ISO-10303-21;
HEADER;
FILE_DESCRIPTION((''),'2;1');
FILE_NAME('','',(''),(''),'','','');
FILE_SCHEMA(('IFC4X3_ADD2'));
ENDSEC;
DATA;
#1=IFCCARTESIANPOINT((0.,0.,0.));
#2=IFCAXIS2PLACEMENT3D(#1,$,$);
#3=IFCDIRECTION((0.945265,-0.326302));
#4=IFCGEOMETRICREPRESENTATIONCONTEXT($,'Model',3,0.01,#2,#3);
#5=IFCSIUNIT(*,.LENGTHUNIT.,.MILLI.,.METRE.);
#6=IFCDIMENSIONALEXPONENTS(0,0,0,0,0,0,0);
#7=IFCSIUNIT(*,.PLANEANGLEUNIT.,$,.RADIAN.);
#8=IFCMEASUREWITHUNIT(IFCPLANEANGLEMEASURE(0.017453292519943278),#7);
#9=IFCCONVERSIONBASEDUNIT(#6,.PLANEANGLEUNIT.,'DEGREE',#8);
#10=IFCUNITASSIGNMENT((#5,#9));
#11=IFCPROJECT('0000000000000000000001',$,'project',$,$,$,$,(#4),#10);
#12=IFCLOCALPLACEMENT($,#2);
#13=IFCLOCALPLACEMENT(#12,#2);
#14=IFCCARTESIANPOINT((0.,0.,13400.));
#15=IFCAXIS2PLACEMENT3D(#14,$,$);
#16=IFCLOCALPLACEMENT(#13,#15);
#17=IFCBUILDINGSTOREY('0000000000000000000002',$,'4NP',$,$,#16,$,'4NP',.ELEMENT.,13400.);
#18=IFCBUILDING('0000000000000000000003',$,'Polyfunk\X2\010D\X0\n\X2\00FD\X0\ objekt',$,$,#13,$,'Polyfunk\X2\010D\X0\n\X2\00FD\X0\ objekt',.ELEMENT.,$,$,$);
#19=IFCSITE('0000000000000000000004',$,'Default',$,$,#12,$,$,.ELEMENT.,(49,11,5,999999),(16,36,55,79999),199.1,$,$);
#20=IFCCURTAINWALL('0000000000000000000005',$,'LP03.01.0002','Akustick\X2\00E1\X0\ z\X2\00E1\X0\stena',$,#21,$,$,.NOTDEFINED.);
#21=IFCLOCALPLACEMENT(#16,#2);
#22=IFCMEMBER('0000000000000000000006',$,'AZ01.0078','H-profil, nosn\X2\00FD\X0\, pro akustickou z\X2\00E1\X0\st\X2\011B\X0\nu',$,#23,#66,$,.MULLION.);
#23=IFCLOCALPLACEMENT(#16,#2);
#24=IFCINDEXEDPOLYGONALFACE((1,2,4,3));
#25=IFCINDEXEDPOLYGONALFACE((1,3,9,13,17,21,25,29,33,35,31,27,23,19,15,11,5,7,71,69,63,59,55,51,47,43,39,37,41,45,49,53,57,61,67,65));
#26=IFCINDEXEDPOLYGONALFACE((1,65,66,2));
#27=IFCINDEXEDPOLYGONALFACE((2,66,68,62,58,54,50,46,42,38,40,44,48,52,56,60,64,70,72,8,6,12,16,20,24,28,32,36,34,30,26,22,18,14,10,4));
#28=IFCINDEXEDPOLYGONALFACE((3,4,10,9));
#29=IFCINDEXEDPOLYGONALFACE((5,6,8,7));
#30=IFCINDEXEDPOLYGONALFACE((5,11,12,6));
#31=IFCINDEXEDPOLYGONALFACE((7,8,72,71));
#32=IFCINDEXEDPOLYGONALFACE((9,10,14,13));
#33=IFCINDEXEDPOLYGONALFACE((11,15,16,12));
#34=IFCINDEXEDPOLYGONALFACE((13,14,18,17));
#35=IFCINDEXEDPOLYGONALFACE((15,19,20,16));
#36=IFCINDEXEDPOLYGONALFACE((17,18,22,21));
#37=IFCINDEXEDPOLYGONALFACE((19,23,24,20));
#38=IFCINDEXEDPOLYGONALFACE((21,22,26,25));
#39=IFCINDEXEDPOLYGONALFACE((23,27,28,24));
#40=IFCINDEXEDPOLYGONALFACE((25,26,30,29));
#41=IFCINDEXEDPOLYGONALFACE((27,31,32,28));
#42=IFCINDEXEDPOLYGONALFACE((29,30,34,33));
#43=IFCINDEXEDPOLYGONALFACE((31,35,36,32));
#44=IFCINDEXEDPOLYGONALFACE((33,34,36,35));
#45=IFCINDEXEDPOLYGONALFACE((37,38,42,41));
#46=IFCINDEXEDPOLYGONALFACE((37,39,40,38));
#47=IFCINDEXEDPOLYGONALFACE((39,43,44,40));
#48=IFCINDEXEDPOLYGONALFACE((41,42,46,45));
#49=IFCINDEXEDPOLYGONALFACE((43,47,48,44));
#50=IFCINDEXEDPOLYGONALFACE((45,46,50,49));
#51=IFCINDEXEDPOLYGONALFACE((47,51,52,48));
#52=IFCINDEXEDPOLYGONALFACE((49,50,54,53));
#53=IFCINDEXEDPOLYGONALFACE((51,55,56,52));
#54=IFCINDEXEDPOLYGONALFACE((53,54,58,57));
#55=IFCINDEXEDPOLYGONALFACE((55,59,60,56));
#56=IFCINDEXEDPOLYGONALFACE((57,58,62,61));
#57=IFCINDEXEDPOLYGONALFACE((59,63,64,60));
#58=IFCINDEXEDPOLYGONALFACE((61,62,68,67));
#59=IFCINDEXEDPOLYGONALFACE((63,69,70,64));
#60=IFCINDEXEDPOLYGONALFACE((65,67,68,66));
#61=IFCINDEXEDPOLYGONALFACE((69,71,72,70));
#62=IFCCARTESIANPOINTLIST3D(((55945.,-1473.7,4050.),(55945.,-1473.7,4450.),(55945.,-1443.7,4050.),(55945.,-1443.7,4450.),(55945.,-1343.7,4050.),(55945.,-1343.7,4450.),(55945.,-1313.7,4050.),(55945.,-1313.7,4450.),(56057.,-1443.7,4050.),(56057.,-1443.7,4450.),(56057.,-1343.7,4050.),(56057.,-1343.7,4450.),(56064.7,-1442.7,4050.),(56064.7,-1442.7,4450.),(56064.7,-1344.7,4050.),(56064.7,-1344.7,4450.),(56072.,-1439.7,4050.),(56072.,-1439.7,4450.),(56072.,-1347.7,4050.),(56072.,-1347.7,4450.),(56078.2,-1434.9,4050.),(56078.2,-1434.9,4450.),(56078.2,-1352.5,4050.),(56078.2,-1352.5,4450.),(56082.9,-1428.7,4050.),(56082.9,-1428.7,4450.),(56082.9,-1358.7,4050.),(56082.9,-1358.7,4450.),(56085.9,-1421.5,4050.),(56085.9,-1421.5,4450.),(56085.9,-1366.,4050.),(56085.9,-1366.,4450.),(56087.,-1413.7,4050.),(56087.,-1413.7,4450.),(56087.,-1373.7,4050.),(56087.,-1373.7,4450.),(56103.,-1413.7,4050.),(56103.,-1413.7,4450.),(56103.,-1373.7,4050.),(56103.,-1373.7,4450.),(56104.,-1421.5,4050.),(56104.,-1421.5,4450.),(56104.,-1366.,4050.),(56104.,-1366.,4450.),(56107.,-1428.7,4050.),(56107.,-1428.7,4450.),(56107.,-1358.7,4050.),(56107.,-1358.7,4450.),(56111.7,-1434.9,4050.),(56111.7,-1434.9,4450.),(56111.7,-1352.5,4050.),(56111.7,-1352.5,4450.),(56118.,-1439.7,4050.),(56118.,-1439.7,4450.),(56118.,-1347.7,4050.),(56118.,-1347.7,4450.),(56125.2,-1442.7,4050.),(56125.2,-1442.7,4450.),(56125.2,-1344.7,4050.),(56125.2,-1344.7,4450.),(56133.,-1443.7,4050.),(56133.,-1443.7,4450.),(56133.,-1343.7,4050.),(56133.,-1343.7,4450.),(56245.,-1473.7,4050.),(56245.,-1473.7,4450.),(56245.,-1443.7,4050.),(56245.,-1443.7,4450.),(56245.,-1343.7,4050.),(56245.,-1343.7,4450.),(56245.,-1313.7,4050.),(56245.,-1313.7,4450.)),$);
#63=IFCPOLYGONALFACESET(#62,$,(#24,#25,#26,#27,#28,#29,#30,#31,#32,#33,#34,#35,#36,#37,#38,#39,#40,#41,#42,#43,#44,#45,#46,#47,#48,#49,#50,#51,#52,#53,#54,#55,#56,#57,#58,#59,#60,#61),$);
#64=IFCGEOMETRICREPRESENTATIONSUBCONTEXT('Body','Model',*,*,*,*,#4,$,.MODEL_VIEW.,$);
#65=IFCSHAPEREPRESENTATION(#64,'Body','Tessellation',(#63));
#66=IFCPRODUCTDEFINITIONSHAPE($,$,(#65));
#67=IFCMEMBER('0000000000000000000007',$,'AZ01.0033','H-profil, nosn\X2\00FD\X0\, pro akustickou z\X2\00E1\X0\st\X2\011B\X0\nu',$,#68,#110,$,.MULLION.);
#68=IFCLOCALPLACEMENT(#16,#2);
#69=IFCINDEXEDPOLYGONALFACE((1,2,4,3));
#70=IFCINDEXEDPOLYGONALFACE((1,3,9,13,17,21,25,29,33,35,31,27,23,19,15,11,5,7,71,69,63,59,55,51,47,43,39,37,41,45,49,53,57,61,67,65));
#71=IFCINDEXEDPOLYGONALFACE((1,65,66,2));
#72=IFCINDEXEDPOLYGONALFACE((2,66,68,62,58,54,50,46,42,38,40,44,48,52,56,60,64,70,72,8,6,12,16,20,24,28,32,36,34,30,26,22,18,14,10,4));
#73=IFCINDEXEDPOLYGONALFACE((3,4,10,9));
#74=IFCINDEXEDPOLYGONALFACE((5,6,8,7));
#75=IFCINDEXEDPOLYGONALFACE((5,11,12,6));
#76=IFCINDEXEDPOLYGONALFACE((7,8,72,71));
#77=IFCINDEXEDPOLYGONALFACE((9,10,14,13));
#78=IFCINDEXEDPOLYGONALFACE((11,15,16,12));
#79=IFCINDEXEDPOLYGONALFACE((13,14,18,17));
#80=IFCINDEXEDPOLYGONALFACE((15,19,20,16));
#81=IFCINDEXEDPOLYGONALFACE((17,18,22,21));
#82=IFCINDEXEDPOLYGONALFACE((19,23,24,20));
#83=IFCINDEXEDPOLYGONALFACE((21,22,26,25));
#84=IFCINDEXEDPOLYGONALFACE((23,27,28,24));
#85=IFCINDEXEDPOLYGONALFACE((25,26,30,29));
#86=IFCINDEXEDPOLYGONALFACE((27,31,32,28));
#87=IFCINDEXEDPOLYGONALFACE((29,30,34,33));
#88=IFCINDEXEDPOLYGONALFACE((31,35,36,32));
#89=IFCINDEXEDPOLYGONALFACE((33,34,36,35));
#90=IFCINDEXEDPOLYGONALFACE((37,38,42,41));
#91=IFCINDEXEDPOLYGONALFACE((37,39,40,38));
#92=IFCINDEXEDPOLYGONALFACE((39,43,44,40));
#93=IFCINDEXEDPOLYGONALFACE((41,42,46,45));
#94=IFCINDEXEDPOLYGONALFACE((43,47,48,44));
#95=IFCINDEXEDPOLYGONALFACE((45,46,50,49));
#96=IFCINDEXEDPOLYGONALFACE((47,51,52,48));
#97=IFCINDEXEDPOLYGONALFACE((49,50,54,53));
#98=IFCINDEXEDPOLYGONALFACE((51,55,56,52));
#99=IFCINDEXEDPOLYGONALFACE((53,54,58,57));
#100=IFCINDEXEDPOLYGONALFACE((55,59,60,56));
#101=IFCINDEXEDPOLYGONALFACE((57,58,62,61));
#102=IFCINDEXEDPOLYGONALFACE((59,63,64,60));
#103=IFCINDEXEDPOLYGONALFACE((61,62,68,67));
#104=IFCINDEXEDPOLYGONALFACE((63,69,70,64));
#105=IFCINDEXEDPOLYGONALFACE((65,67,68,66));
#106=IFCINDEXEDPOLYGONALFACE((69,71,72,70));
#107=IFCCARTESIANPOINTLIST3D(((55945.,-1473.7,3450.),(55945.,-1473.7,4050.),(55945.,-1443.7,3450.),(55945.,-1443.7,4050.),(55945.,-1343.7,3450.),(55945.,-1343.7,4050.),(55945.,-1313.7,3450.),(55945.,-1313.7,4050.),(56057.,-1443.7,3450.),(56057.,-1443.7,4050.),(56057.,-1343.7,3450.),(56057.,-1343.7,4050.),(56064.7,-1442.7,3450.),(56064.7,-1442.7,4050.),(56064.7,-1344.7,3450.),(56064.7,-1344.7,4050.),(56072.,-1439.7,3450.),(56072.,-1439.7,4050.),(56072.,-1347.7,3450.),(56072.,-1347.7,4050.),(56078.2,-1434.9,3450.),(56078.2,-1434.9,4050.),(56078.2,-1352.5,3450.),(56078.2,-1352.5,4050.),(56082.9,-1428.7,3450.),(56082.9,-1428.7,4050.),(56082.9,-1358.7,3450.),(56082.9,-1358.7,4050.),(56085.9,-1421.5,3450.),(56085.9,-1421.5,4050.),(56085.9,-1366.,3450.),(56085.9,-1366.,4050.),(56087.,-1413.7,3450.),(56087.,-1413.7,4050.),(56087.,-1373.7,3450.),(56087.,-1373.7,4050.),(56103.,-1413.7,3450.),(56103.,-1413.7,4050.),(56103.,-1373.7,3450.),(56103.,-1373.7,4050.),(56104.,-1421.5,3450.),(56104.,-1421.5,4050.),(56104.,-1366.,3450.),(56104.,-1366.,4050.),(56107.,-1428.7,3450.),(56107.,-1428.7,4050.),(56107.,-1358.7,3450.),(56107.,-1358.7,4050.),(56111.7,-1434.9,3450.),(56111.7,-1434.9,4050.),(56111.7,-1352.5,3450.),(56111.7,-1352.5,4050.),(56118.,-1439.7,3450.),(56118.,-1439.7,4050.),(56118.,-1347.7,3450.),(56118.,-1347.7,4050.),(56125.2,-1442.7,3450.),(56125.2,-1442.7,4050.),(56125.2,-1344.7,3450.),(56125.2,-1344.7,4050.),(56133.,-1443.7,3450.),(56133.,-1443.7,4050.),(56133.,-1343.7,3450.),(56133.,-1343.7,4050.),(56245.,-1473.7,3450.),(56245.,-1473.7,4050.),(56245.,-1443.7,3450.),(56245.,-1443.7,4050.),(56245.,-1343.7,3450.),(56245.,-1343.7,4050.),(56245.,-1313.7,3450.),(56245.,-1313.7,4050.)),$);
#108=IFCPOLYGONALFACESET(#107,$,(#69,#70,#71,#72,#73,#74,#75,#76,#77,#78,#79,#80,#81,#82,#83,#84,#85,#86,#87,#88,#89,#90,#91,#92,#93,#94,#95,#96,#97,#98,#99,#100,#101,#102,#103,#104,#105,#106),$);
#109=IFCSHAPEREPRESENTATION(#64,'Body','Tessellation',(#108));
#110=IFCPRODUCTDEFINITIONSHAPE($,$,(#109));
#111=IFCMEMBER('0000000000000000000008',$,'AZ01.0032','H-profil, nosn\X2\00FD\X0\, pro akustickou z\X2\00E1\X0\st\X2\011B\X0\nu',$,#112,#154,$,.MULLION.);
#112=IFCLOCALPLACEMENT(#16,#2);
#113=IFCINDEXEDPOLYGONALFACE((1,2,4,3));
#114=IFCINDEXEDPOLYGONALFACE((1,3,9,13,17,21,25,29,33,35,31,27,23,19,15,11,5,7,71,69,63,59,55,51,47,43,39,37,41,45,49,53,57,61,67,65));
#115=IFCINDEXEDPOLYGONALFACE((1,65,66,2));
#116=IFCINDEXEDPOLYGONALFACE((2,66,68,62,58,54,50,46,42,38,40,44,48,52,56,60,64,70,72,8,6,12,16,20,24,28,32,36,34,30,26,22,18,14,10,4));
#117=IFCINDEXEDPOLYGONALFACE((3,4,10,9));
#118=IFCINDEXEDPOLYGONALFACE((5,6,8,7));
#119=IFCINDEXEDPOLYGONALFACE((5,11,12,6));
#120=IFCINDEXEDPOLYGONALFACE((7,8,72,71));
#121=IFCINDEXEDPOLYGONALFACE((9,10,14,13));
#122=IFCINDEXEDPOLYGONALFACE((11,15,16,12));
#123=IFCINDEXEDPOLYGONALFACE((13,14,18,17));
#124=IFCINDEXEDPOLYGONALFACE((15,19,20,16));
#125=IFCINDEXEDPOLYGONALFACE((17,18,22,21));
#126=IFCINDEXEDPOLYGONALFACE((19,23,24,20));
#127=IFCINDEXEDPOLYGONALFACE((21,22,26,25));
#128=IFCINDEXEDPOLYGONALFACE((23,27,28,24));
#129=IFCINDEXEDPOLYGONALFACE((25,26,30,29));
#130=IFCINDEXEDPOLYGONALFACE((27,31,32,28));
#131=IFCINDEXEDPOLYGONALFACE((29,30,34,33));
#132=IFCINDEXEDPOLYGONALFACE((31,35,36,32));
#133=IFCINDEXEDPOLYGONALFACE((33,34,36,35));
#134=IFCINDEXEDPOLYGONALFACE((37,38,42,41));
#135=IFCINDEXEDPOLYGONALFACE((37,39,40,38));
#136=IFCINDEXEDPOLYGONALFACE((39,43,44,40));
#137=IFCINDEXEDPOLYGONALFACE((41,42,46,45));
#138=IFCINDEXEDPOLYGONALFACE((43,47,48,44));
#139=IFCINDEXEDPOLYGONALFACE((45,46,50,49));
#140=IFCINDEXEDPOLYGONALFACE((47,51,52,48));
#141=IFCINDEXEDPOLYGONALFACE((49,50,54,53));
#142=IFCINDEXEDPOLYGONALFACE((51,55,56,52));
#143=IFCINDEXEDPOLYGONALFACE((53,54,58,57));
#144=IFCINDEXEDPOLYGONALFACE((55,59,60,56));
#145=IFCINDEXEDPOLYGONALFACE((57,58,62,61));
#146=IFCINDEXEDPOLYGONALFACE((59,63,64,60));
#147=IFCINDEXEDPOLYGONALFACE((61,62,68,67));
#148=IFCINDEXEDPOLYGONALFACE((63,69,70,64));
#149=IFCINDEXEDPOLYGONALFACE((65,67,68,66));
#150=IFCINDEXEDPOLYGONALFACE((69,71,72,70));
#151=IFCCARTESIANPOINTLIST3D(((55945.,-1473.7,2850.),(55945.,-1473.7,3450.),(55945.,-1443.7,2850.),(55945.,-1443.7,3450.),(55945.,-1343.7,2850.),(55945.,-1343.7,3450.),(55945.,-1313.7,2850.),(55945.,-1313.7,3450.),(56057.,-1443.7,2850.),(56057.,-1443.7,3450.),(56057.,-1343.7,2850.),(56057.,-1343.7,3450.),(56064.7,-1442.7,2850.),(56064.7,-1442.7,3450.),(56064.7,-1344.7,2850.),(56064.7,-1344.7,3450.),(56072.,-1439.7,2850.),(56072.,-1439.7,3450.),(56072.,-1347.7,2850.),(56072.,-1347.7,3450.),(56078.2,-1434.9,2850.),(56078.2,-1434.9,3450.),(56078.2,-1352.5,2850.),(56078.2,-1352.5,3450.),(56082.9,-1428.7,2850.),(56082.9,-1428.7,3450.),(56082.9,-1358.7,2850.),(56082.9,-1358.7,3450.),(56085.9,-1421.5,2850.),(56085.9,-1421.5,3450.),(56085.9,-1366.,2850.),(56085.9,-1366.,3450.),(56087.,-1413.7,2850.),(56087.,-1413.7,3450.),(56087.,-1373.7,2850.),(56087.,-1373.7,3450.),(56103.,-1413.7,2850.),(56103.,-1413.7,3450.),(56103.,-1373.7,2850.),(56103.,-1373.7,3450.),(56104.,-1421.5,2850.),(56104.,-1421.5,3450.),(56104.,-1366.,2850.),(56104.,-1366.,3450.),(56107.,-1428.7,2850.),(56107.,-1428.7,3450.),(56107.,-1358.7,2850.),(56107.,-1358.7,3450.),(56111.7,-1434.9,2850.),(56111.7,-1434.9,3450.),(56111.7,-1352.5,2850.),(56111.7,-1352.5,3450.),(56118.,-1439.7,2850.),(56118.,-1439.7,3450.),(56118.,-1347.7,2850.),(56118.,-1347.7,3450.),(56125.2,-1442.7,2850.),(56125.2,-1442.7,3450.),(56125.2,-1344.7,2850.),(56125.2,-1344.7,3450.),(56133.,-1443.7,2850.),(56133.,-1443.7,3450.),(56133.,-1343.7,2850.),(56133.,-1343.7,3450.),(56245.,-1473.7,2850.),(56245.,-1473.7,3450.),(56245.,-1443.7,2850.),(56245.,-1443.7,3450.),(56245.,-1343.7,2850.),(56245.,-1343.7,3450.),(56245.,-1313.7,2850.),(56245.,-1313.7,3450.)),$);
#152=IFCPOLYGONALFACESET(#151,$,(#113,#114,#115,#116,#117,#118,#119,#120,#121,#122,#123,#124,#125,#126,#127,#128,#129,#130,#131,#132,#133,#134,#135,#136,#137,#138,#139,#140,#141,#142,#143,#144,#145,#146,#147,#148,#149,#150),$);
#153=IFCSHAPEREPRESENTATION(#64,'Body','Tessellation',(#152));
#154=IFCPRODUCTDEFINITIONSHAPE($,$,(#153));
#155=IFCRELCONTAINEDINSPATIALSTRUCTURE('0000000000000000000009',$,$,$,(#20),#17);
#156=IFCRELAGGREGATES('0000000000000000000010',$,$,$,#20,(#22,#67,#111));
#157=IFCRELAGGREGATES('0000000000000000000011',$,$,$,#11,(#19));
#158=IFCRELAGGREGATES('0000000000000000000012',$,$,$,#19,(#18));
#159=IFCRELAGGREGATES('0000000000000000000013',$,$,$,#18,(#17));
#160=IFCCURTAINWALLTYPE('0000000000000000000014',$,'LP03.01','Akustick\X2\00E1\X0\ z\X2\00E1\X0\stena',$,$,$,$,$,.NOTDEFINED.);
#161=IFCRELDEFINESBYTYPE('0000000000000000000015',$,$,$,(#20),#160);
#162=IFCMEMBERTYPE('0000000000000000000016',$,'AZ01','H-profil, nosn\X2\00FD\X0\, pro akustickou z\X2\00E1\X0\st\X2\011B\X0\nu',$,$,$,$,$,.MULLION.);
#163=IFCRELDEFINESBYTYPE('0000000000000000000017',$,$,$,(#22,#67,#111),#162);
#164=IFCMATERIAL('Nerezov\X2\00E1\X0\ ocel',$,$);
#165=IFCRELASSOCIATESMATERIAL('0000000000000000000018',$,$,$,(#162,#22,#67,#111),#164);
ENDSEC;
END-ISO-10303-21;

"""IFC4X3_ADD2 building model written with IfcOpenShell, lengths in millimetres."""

from ifc_helpers import new_model, entity, si_unit, converted_unit, direction, frame, frame_2d, origin, place, context, subcontext, project, spatial, polyline, circle_curve, parameter, trimmed, segment, composite_curve, outline, extrude, source, transform, mapped, material, material_profile, profile_set, profile_usage, type_object, element, aggregate, save


model = new_model("IFC4X3_ADD2")

# Units and contexts
model_context = context("Model", 3, precision=0.01, world=origin(), true_north=direction((0.945265, -0.326302)))
body_context = subcontext(model_context, "Body", "Model", "MODEL_VIEW")
ifc_project = project(units=[si_unit("LENGTHUNIT", "METRE", prefix="MILLI"), converted_unit("PLANEANGLEUNIT", "DEGREE", entity("IfcPlaneAngleMeasure", 0.017453292519943278), si_unit("PLANEANGLEUNIT", "RADIAN"), dimensions=[0, 0, 0, 0, 0, 0, 0])], contexts=[model_context])

# Site, building, storey
site_placement = place(None, origin())
site = spatial("IfcSite", under=ifc_project, at=site_placement, Name="Default", CompositionType="ELEMENT", RefLatitude=(49, 11, 5, 999999), RefLongitude=(16, 36, 55, 79999), RefElevation=199.1)
building_placement = place(site_placement, origin())
building = spatial("IfcBuilding", under=site, at=building_placement, Name="Polyfunkčný objekt", LongName="Polyfunkčný objekt", CompositionType="ELEMENT")
storey_placement = place(building_placement, frame((0.0, 0.0, 13400.0)))
storey = spatial("IfcBuildingStorey", under=building, at=storey_placement, Name="4NP", LongName="4NP", CompositionType="ELEMENT", Elevation=13400.0)

# Curtain wall, members
curtain_wall_type_1 = type_object("IfcCurtainWallType", Name="LP03.01", Description="Akustická zástena", PredefinedType="NOTDEFINED")
curtain_wall_1_placement = place(storey_placement, frame((0.0, 0.0, -13400.0)))
curtain_wall_1 = element("IfcCurtainWall", 1, at=curtain_wall_1_placement, inside=storey, type_object=curtain_wall_type_1, Name="LP03.01.0002", Description="Akustická zástena", PredefinedType="NOTDEFINED")
ifc_material_1 = material(Name="Nerezová ocel")
ifc_material_profile = material_profile(ifc_material_1, outline(composite_curve([segment(polyline([(50.0, -150.0), (80.0, -150.0)]), True, "CONTINUOUS"), segment(polyline([(80.0, -150.0), (80.0, 150.0)]), True, "CONTINUOUS"), segment(polyline([(80.0, 150.0), (50.0, 150.0)]), True, "CONTINUOUS"), segment(polyline([(50.0, 150.0), (50.0, 38.0)]), True, "CONTINUOUS"), segment(trimmed(circle_curve(frame_2d((20.0, 38.0), x_axis=(0.0, 1.0)), 30.0), [parameter(180.0)], [parameter(270.0)], True, "PARAMETER"), False, "CONTINUOUS"), segment(polyline([(20.0, 8.0), (-20.0, 8.0)]), True, "CONTINUOUS"), segment(trimmed(circle_curve(frame_2d((-20.0, 38.0), x_axis=(0.0, 1.0)), 30.0), [parameter(90.0)], [parameter(180.0)], True, "PARAMETER"), False, "CONTINUOUS"), segment(polyline([(-50.0, 38.0), (-50.0, 150.0)]), True, "CONTINUOUS"), segment(polyline([(-50.0, 150.0), (-80.0, 150.0)]), True, "CONTINUOUS"), segment(polyline([(-80.0, 150.0), (-80.0, -150.0)]), True, "CONTINUOUS"), segment(polyline([(-80.0, -150.0), (-50.0, -150.0)]), True, "CONTINUOUS"), segment(polyline([(-50.0, -150.0), (-50.0, -38.0)]), True, "CONTINUOUS"), segment(trimmed(circle_curve(frame_2d((-20.0, -38.0), x_axis=(0.0, 1.0)), 30.0), [parameter(0.0)], [parameter(90.0)], True, "PARAMETER"), False, "CONTINUOUS"), segment(polyline([(-20.0, -8.0), (20.0, -8.0)]), True, "CONTINUOUS"), segment(trimmed(circle_curve(frame_2d((20.0, -38.0), x_axis=(0.0, 1.0)), 30.0), [parameter(270.0)], [parameter(0.0)], True, "PARAMETER"), False, "CONTINUOUS"), segment(polyline([(50.0, -38.0), (50.0, -150.0)]), True, "CONTINUOUS")], self_intersect=False)), Name="Profil zástena")
ifc_profile_set = profile_set([ifc_material_profile], Name="Profil zástena")
ifc_profile_usage = profile_usage(ifc_profile_set)
member_type = type_object("IfcMemberType", Name="AZ01", Description="H-profil, nosný, pro akustickou zástěnu", PredefinedType="MULLION", material=ifc_profile_set)
shared_shape_1 = source(origin(), body_context, "Body", "SweptSolid", [
    extrude(outline(composite_curve([segment(polyline([(50.0, -150.0), (80.0, -150.0)]), True, "CONTINUOUS"), segment(polyline([(80.0, -150.0), (80.0, 150.0)]), True, "CONTINUOUS"), segment(polyline([(80.0, 150.0), (50.0, 150.0)]), True, "CONTINUOUS"), segment(polyline([(50.0, 150.0), (50.0, 38.0)]), True, "CONTINUOUS"), segment(trimmed(circle_curve(frame_2d((20.0, 38.0), x_axis=(0.0, 1.0)), 30.0), [parameter(180.0)], [parameter(270.0)], True, "PARAMETER"), False, "CONTINUOUS"), segment(polyline([(20.0, 8.0), (-20.0, 8.0)]), True, "CONTINUOUS"), segment(trimmed(circle_curve(frame_2d((-20.0, 38.0), x_axis=(0.0, 1.0)), 30.0), [parameter(90.0)], [parameter(180.0)], True, "PARAMETER"), False, "CONTINUOUS"), segment(polyline([(-50.0, 38.0), (-50.0, 150.0)]), True, "CONTINUOUS"), segment(polyline([(-50.0, 150.0), (-80.0, 150.0)]), True, "CONTINUOUS"), segment(polyline([(-80.0, 150.0), (-80.0, -150.0)]), True, "CONTINUOUS"), segment(polyline([(-80.0, -150.0), (-50.0, -150.0)]), True, "CONTINUOUS"), segment(polyline([(-50.0, -150.0), (-50.0, -38.0)]), True, "CONTINUOUS"), segment(trimmed(circle_curve(frame_2d((-20.0, -38.0), x_axis=(0.0, 1.0)), 30.0), [parameter(0.0)], [parameter(90.0)], True, "PARAMETER"), False, "CONTINUOUS"), segment(polyline([(-20.0, -8.0), (20.0, -8.0)]), True, "CONTINUOUS"), segment(trimmed(circle_curve(frame_2d((20.0, -38.0), x_axis=(0.0, 1.0)), 30.0), [parameter(270.0)], [parameter(0.0)], True, "PARAMETER"), False, "CONTINUOUS"), segment(polyline([(50.0, -38.0), (50.0, -150.0)]), True, "CONTINUOUS")], self_intersect=False)), frame((-150.0, 0.0, -400.0), z_axis=(0.0, 0.0, 1.0), x_axis=(0.0, -1.0, 0.0)), (0.0, 0.0, 1.0), 400.0),
])
member_1_placement = place(curtain_wall_1_placement, frame((56245.0, -1393.7, 17450.0), z_axis=(0.0, 0.0, -1.0), x_axis=(1.0, 0.0, 0.0)))
member_1 = element("IfcMember", 2, at=member_1_placement, type_object=member_type, material=ifc_profile_usage, Name="AZ01.0078", Description="H-profil, nosný, pro akustickou zástěnu", PredefinedType="MULLION", context=body_context, shape_type="MappedRepresentation", body=[
    mapped(shared_shape_1, transform((0.0, 0.0, 0.0), scale=1.0)),
])
shared_shape_2 = source(origin(), body_context, "Body", "SweptSolid", [
    extrude(outline(composite_curve([segment(polyline([(50.0, -150.0), (80.0, -150.0)]), True, "CONTINUOUS"), segment(polyline([(80.0, -150.0), (80.0, 150.0)]), True, "CONTINUOUS"), segment(polyline([(80.0, 150.0), (50.0, 150.0)]), True, "CONTINUOUS"), segment(polyline([(50.0, 150.0), (50.0, 38.0)]), True, "CONTINUOUS"), segment(trimmed(circle_curve(frame_2d((20.0, 38.0), x_axis=(0.0, 1.0)), 30.0), [parameter(180.0)], [parameter(270.0)], True, "PARAMETER"), False, "CONTINUOUS"), segment(polyline([(20.0, 8.0), (-20.0, 8.0)]), True, "CONTINUOUS"), segment(trimmed(circle_curve(frame_2d((-20.0, 38.0), x_axis=(0.0, 1.0)), 30.0), [parameter(90.0)], [parameter(180.0)], True, "PARAMETER"), False, "CONTINUOUS"), segment(polyline([(-50.0, 38.0), (-50.0, 150.0)]), True, "CONTINUOUS"), segment(polyline([(-50.0, 150.0), (-80.0, 150.0)]), True, "CONTINUOUS"), segment(polyline([(-80.0, 150.0), (-80.0, -150.0)]), True, "CONTINUOUS"), segment(polyline([(-80.0, -150.0), (-50.0, -150.0)]), True, "CONTINUOUS"), segment(polyline([(-50.0, -150.0), (-50.0, -38.0)]), True, "CONTINUOUS"), segment(trimmed(circle_curve(frame_2d((-20.0, -38.0), x_axis=(0.0, 1.0)), 30.0), [parameter(0.0)], [parameter(90.0)], True, "PARAMETER"), False, "CONTINUOUS"), segment(polyline([(-20.0, -8.0), (20.0, -8.0)]), True, "CONTINUOUS"), segment(trimmed(circle_curve(frame_2d((20.0, -38.0), x_axis=(0.0, 1.0)), 30.0), [parameter(270.0)], [parameter(0.0)], True, "PARAMETER"), False, "CONTINUOUS"), segment(polyline([(50.0, -38.0), (50.0, -150.0)]), True, "CONTINUOUS")], self_intersect=False)), frame((-150.0, 0.0, -600.0), z_axis=(0.0, 0.0, 1.0), x_axis=(0.0, -1.0, 0.0)), (0.0, 0.0, 1.0), 600.0),
])
member_2_placement = place(curtain_wall_1_placement, frame((56245.0, -1393.7, 16850.0), z_axis=(0.0, 0.0, -1.0), x_axis=(1.0, 0.0, 0.0)))
member_2 = element("IfcMember", 3, at=member_2_placement, type_object=member_type, material=ifc_profile_usage, Name="AZ01.0033", Description="H-profil, nosný, pro akustickou zástěnu", PredefinedType="MULLION", context=body_context, shape_type="MappedRepresentation", body=[
    mapped(shared_shape_2, transform((0.0, 0.0, 0.0), scale=1.0)),
])
member_3_placement = place(curtain_wall_1_placement, frame((56245.0, -1393.7, 16250.0), z_axis=(0.0, 0.0, -1.0), x_axis=(1.0, 0.0, 0.0)))
member_3 = element("IfcMember", 4, at=member_3_placement, type_object=member_type, material=ifc_profile_usage, Name="AZ01.0032", Description="H-profil, nosný, pro akustickou zástěnu", PredefinedType="MULLION", context=body_context, shape_type="MappedRepresentation", body=[
    mapped(shared_shape_2, transform((0.0, 0.0, 0.0), scale=1.0)),
])
aggregate(curtain_wall_1, [member_1, member_2, member_3])

save(model, "model.ifc")
